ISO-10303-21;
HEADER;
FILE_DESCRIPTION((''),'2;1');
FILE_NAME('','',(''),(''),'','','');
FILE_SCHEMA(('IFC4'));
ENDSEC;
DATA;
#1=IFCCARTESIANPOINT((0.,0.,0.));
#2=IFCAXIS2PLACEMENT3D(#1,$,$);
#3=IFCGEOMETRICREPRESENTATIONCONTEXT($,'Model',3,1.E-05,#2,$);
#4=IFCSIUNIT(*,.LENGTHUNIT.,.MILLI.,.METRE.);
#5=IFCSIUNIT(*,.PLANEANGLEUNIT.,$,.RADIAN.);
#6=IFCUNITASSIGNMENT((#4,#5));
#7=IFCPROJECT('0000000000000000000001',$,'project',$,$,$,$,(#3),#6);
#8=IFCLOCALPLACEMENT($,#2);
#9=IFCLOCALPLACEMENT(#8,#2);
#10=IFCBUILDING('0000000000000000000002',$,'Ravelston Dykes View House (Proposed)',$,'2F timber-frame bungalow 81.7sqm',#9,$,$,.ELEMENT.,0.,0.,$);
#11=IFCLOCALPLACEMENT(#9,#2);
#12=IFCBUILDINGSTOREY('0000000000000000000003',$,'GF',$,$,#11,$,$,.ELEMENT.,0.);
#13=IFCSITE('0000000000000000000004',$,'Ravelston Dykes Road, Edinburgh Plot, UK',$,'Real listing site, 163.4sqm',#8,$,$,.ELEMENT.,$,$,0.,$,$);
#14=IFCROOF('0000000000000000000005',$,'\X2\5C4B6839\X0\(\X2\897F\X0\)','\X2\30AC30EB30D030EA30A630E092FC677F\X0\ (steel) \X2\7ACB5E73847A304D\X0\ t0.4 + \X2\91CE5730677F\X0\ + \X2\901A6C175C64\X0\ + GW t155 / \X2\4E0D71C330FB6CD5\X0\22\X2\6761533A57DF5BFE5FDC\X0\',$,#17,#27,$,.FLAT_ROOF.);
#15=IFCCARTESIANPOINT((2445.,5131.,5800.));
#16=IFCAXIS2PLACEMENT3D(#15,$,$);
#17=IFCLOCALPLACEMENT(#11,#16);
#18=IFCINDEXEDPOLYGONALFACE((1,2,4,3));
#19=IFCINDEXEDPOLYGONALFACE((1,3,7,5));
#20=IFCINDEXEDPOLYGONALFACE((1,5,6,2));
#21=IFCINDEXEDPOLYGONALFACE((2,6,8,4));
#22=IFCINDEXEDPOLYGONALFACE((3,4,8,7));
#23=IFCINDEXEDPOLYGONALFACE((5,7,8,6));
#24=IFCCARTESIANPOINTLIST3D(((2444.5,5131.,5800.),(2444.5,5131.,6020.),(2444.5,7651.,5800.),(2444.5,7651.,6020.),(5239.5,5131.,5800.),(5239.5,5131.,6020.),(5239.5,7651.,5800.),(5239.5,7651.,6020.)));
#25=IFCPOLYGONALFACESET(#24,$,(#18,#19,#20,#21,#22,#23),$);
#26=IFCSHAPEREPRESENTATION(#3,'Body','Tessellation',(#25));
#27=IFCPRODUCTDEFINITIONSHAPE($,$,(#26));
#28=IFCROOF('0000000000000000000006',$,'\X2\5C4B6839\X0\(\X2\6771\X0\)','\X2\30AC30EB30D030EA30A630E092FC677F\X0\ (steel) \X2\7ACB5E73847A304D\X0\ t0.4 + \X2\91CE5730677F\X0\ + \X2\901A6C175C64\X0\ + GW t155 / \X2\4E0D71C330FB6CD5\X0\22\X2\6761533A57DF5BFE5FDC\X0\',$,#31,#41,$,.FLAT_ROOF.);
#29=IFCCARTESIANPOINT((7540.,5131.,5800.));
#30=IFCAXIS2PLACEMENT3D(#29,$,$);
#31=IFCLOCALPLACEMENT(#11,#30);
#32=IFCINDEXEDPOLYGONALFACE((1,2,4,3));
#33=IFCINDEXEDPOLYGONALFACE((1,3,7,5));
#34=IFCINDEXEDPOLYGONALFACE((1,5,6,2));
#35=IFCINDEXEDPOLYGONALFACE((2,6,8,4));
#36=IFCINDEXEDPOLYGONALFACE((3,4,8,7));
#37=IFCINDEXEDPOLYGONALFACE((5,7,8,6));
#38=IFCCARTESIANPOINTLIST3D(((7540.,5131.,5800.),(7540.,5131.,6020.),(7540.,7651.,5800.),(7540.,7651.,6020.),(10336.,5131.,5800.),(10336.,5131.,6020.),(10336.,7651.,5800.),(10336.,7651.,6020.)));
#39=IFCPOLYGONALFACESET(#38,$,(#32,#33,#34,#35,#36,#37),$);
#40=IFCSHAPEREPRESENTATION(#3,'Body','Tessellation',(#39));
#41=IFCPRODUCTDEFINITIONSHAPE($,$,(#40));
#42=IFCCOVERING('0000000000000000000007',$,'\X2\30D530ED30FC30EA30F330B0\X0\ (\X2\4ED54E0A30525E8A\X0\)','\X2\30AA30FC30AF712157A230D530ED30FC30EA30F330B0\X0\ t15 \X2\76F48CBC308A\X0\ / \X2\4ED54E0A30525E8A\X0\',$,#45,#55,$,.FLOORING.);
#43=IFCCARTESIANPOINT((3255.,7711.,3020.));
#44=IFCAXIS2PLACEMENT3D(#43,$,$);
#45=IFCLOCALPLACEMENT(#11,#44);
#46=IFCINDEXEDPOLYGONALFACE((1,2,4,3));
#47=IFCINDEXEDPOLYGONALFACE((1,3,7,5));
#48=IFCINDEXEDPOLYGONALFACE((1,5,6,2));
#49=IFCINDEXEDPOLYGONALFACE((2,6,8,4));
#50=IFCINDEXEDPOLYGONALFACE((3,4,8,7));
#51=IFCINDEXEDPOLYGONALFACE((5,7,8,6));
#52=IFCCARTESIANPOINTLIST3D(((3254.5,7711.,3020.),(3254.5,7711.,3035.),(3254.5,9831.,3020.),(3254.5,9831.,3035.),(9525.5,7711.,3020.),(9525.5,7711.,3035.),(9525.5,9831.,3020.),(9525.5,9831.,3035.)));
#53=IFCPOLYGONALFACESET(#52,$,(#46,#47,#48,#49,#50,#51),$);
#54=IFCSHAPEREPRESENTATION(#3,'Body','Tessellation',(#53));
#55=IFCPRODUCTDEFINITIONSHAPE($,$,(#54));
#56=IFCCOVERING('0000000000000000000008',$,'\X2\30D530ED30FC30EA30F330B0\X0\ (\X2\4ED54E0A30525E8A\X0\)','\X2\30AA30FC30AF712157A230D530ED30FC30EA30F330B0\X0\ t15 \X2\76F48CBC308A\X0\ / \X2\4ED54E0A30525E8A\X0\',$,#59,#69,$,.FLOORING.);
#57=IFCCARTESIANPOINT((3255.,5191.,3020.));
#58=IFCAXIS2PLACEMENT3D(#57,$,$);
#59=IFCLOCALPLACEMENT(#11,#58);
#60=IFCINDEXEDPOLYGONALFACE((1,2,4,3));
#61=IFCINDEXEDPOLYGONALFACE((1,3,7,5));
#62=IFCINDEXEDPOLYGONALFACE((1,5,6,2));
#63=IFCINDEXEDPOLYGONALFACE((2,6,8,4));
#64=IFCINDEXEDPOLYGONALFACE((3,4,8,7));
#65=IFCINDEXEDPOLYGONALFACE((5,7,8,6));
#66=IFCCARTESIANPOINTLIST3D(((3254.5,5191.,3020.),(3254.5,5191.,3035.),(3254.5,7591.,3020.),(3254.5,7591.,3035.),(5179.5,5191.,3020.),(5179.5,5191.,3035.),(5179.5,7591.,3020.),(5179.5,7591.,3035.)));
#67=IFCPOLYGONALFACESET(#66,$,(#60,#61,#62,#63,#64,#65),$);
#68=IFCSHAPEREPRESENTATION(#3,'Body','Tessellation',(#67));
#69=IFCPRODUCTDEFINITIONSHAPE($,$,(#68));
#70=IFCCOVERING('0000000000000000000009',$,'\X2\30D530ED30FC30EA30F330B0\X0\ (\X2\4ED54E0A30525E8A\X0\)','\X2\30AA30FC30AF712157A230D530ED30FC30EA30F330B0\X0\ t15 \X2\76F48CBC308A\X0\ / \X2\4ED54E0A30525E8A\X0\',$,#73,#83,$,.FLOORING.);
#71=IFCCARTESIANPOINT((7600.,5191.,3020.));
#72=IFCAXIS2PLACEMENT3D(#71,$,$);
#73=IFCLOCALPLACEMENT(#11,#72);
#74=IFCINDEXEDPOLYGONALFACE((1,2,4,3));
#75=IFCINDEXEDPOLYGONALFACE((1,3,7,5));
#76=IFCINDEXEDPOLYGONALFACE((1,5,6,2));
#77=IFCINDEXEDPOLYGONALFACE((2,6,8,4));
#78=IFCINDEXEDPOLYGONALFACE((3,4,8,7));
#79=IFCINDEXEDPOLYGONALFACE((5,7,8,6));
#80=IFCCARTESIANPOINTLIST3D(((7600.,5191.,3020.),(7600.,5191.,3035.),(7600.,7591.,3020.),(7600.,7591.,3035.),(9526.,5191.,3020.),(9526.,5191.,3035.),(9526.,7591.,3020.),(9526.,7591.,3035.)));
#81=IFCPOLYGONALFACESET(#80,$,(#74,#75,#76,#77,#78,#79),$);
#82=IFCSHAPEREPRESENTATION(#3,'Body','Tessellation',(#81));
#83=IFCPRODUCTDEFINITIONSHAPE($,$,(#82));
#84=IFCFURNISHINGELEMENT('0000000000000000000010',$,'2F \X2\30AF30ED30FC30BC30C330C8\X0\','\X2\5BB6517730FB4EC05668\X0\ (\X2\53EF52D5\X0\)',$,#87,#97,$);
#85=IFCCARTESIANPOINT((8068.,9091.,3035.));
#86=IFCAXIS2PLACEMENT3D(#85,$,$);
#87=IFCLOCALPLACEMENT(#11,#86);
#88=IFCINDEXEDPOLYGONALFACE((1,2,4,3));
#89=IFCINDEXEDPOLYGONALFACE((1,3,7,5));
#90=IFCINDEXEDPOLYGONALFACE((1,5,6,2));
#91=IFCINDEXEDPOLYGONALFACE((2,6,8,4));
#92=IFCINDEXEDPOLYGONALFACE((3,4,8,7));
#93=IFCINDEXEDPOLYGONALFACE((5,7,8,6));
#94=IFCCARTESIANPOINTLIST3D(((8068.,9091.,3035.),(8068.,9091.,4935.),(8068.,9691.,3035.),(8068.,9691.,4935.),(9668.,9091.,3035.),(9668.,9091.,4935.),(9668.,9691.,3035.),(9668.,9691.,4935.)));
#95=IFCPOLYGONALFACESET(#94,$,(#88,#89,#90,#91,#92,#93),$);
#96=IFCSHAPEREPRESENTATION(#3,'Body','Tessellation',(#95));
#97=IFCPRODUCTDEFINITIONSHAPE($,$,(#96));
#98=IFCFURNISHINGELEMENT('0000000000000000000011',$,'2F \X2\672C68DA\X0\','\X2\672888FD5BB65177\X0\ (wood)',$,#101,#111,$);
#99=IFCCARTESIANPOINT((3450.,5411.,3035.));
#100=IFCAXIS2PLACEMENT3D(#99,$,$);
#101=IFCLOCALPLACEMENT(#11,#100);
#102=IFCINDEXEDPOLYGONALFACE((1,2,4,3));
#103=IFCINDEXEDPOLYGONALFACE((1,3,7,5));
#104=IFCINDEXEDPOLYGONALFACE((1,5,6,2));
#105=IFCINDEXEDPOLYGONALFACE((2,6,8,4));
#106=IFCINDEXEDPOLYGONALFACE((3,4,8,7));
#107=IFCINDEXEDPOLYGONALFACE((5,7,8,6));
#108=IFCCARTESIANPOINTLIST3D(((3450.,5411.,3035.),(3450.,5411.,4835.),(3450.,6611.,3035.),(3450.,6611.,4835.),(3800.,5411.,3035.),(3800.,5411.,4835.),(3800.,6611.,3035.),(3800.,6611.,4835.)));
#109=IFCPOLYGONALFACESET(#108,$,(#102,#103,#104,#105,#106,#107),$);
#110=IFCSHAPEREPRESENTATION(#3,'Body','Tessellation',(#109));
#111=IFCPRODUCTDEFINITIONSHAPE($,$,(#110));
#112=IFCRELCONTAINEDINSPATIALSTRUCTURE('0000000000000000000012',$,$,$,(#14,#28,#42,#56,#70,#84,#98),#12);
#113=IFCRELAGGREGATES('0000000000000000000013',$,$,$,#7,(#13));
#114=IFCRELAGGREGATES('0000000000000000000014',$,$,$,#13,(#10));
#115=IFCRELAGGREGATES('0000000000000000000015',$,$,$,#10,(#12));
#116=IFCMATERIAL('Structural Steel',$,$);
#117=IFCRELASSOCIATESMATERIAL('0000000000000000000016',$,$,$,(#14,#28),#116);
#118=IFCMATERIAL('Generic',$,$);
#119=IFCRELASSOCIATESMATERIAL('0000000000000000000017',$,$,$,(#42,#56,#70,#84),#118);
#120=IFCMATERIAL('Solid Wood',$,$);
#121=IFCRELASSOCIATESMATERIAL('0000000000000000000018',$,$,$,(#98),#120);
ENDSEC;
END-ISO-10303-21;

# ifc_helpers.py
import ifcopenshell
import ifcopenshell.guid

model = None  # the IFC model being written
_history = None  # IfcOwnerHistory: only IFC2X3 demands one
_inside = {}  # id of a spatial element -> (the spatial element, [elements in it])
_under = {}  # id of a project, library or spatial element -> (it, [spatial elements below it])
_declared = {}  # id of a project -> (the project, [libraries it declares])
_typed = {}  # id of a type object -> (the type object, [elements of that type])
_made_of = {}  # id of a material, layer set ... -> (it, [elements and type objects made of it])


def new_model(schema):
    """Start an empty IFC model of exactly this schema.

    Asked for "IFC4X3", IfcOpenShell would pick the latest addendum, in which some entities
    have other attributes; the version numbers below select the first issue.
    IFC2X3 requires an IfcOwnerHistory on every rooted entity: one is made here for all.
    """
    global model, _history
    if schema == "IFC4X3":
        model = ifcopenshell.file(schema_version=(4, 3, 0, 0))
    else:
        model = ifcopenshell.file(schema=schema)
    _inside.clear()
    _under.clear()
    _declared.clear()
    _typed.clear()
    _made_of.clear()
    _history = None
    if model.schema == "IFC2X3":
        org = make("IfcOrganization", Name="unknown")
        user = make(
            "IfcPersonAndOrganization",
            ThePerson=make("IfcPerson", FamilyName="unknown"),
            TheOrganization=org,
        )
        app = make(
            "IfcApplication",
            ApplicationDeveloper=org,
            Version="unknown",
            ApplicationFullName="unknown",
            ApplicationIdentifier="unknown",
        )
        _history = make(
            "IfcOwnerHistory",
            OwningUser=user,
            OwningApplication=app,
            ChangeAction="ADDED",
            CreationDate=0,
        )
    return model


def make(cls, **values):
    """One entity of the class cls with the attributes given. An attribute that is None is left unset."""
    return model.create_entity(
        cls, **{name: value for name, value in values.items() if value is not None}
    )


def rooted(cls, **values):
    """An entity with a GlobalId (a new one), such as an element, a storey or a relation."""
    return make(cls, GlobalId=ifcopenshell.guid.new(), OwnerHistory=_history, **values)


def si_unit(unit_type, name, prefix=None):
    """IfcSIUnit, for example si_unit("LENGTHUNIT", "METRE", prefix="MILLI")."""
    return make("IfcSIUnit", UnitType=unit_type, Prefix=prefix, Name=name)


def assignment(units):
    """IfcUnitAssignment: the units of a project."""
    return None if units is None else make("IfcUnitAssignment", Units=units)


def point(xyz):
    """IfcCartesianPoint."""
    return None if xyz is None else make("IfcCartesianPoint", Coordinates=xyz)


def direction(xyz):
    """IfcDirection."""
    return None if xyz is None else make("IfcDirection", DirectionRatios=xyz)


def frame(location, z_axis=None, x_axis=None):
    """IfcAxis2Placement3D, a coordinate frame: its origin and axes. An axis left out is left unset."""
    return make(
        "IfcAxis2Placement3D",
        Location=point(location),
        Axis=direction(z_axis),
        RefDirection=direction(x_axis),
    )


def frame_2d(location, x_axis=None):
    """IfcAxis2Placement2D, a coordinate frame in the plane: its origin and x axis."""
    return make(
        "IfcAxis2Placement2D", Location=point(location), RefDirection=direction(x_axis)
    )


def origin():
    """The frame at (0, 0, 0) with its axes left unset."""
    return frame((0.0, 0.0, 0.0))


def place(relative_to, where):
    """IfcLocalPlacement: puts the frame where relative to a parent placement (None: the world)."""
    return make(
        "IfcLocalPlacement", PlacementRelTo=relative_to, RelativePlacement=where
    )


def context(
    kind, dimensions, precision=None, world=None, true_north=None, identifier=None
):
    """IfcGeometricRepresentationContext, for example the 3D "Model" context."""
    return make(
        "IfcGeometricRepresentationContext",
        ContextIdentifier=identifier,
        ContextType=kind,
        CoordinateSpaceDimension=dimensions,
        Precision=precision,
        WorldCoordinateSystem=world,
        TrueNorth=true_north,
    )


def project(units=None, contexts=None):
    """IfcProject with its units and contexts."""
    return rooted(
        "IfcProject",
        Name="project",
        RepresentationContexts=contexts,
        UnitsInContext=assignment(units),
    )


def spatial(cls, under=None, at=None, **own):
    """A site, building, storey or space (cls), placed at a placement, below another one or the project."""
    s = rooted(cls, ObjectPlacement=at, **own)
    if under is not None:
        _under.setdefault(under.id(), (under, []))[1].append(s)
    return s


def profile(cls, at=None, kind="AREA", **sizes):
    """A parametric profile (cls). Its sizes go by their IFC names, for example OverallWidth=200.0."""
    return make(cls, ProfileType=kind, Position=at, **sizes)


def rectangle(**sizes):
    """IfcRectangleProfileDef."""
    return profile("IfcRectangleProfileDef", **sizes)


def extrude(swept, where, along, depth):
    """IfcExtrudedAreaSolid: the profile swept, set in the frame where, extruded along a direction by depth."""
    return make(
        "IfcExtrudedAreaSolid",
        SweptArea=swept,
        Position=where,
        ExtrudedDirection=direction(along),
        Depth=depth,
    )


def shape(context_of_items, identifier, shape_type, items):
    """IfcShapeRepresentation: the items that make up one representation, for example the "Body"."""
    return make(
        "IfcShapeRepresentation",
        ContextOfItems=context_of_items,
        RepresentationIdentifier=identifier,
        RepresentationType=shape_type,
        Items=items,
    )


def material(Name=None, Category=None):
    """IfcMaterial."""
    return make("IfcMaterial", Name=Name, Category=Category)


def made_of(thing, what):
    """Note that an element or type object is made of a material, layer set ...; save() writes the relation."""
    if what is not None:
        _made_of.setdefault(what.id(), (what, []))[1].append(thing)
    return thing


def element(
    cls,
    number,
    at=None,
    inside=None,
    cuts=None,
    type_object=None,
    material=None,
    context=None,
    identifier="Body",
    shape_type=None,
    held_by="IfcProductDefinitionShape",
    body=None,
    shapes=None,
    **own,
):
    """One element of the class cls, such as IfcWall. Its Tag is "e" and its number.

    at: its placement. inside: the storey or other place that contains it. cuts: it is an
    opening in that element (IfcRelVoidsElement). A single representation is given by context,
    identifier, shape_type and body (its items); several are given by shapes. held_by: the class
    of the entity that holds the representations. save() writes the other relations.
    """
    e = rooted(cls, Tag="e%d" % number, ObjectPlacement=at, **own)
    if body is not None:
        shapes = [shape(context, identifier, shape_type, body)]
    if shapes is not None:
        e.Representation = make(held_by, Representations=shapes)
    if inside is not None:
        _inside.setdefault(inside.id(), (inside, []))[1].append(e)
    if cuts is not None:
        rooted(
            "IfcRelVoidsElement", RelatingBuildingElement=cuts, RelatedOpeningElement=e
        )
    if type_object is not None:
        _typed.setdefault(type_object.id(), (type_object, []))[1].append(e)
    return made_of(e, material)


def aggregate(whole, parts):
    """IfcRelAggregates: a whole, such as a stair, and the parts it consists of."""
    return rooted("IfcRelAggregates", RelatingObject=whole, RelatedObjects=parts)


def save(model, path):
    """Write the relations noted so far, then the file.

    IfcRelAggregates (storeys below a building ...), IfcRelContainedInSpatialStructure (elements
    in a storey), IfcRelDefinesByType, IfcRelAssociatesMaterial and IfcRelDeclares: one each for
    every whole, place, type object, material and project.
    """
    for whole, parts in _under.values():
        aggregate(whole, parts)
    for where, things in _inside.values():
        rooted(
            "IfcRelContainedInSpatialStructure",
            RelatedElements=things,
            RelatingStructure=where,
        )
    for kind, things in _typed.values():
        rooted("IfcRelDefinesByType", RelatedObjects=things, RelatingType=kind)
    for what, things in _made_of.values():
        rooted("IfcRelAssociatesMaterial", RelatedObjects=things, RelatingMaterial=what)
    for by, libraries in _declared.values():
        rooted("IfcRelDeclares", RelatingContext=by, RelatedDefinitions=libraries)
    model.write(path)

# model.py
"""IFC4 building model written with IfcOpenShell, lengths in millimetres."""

from ifc_helpers import new_model, si_unit, frame, frame_2d, origin, place, context, project, spatial, rectangle, extrude, material, element, save


model = new_model("IFC4")

# Units and contexts
model_context = context("Model", 3, precision=1e-05, world=origin())
ifc_project = project(units=[si_unit("LENGTHUNIT", "METRE", prefix="MILLI"), si_unit("PLANEANGLEUNIT", "RADIAN")], contexts=[model_context])

# Site, building, storey
site_placement = place(None, origin())
site = spatial("IfcSite", under=ifc_project, at=site_placement, Name="Ravelston Dykes Road, Edinburgh Plot, UK", ObjectType="Real listing site, 163.4sqm", CompositionType="ELEMENT", RefElevation=0.0)
building_placement = place(site_placement, origin())
building = spatial("IfcBuilding", under=site, at=building_placement, Name="Ravelston Dykes View House (Proposed)", ObjectType="2F timber-frame bungalow 81.7sqm", CompositionType="ELEMENT", ElevationOfRefHeight=0.0, ElevationOfTerrain=0.0)
storey_placement = place(building_placement, origin())
storey = spatial("IfcBuildingStorey", under=building, at=storey_placement, Name="GF", CompositionType="ELEMENT", Elevation=0.0)

# Shared definitions
ifc_material_1 = material(Name="Solid Wood")

# Roofs
ifc_material_2 = material(Name="Structural Steel")
roof_1_placement = place(storey_placement, frame((2445.0, 5131.0, 5800.0)))
element("IfcRoof", 1, at=roof_1_placement, inside=storey, material=ifc_material_2, Name="屋根(西)", Description="ガルバリウム鋼板 (steel) 立平葺き t0.4 + 野地板 + 通気層 + GW t155 / 不燃・法22条区域対応", PredefinedType="FLAT_ROOF", context=model_context, shape_type="SweptSolid", body=[
    extrude(rectangle(XDim=2795.0, YDim=2520.0, at=frame_2d((1397.0, 1260.0))), frame((2445.0, 5131.0, 5800.0)), (0.0, 0.0, 1.0), 220.0),
])
roof_2_placement = place(storey_placement, frame((7540.0, 5131.0, 5800.0)))
element("IfcRoof", 2, at=roof_2_placement, inside=storey, material=ifc_material_2, Name="屋根(東)", Description="ガルバリウム鋼板 (steel) 立平葺き t0.4 + 野地板 + 通気層 + GW t155 / 不燃・法22条区域対応", PredefinedType="FLAT_ROOF", context=model_context, shape_type="SweptSolid", body=[
    extrude(rectangle(XDim=2796.0, YDim=2520.0, at=frame_2d((1398.0, 1260.0))), frame((7540.0, 5131.0, 5800.0)), (0.0, 0.0, 1.0), 220.0),
])

# Coverings
ifc_material_3 = material(Name="Generic")
covering_1_placement = place(storey_placement, frame((3255.0, 7711.0, 3020.0)))
element("IfcCovering", 3, at=covering_1_placement, inside=storey, material=ifc_material_3, Name="フローリング (仕上げ床)", Description="オーク無垢フローリング t15 直貼り / 仕上げ床", PredefinedType="FLOORING", context=model_context, shape_type="SweptSolid", body=[
    extrude(rectangle(XDim=6271.0, YDim=2120.0, at=frame_2d((3135.0, 1060.0))), frame((3255.0, 7711.0, 3020.0)), (0.0, 0.0, 1.0), 15.0),
])
covering_2_placement = place(storey_placement, frame((3255.0, 5191.0, 3020.0)))
element("IfcCovering", 4, at=covering_2_placement, inside=storey, material=ifc_material_3, Name="フローリング (仕上げ床)", Description="オーク無垢フローリング t15 直貼り / 仕上げ床", PredefinedType="FLOORING", context=model_context, shape_type="SweptSolid", body=[
    extrude(rectangle(XDim=1925.0, YDim=2400.0, at=frame_2d((962.0, 1200.0))), frame((3255.0, 5191.0, 3020.0)), (0.0, 0.0, 1.0), 15.0),
])
covering_3_placement = place(storey_placement, frame((7600.0, 5191.0, 3020.0)))
element("IfcCovering", 5, at=covering_3_placement, inside=storey, material=ifc_material_3, Name="フローリング (仕上げ床)", Description="オーク無垢フローリング t15 直貼り / 仕上げ床", PredefinedType="FLOORING", context=model_context, shape_type="SweptSolid", body=[
    extrude(rectangle(XDim=1926.0, YDim=2400.0, at=frame_2d((963.0, 1200.0))), frame((7600.0, 5191.0, 3020.0)), (0.0, 0.0, 1.0), 15.0),
])

# Furnishing elements
furnishing_1_placement = place(storey_placement, frame((8068.0, 9091.0, 3035.0)))
element("IfcFurnishingElement", 6, at=furnishing_1_placement, inside=storey, material=ifc_material_3, Name="2F クローゼット", Description="家具・什器 (可動)", context=model_context, shape_type="SweptSolid", body=[
    extrude(rectangle(XDim=1600.0, YDim=600.0, at=frame_2d((800.0, 300.0))), frame((8068.0, 9091.0, 3035.0)), (0.0, 0.0, 1.0), 1900.0),
])
furnishing_2_placement = place(storey_placement, frame((3450.0, 5411.0, 3035.0)))
element("IfcFurnishingElement", 7, at=furnishing_2_placement, inside=storey, material=ifc_material_1, Name="2F 本棚", Description="木製家具 (wood)", context=model_context, shape_type="SweptSolid", body=[
    extrude(rectangle(XDim=350.0, YDim=1200.0, at=frame_2d((175.0, 600.0))), frame((3450.0, 5411.0, 3035.0)), (0.0, 0.0, 1.0), 1800.0),
])

save(model, "model.ifc")
